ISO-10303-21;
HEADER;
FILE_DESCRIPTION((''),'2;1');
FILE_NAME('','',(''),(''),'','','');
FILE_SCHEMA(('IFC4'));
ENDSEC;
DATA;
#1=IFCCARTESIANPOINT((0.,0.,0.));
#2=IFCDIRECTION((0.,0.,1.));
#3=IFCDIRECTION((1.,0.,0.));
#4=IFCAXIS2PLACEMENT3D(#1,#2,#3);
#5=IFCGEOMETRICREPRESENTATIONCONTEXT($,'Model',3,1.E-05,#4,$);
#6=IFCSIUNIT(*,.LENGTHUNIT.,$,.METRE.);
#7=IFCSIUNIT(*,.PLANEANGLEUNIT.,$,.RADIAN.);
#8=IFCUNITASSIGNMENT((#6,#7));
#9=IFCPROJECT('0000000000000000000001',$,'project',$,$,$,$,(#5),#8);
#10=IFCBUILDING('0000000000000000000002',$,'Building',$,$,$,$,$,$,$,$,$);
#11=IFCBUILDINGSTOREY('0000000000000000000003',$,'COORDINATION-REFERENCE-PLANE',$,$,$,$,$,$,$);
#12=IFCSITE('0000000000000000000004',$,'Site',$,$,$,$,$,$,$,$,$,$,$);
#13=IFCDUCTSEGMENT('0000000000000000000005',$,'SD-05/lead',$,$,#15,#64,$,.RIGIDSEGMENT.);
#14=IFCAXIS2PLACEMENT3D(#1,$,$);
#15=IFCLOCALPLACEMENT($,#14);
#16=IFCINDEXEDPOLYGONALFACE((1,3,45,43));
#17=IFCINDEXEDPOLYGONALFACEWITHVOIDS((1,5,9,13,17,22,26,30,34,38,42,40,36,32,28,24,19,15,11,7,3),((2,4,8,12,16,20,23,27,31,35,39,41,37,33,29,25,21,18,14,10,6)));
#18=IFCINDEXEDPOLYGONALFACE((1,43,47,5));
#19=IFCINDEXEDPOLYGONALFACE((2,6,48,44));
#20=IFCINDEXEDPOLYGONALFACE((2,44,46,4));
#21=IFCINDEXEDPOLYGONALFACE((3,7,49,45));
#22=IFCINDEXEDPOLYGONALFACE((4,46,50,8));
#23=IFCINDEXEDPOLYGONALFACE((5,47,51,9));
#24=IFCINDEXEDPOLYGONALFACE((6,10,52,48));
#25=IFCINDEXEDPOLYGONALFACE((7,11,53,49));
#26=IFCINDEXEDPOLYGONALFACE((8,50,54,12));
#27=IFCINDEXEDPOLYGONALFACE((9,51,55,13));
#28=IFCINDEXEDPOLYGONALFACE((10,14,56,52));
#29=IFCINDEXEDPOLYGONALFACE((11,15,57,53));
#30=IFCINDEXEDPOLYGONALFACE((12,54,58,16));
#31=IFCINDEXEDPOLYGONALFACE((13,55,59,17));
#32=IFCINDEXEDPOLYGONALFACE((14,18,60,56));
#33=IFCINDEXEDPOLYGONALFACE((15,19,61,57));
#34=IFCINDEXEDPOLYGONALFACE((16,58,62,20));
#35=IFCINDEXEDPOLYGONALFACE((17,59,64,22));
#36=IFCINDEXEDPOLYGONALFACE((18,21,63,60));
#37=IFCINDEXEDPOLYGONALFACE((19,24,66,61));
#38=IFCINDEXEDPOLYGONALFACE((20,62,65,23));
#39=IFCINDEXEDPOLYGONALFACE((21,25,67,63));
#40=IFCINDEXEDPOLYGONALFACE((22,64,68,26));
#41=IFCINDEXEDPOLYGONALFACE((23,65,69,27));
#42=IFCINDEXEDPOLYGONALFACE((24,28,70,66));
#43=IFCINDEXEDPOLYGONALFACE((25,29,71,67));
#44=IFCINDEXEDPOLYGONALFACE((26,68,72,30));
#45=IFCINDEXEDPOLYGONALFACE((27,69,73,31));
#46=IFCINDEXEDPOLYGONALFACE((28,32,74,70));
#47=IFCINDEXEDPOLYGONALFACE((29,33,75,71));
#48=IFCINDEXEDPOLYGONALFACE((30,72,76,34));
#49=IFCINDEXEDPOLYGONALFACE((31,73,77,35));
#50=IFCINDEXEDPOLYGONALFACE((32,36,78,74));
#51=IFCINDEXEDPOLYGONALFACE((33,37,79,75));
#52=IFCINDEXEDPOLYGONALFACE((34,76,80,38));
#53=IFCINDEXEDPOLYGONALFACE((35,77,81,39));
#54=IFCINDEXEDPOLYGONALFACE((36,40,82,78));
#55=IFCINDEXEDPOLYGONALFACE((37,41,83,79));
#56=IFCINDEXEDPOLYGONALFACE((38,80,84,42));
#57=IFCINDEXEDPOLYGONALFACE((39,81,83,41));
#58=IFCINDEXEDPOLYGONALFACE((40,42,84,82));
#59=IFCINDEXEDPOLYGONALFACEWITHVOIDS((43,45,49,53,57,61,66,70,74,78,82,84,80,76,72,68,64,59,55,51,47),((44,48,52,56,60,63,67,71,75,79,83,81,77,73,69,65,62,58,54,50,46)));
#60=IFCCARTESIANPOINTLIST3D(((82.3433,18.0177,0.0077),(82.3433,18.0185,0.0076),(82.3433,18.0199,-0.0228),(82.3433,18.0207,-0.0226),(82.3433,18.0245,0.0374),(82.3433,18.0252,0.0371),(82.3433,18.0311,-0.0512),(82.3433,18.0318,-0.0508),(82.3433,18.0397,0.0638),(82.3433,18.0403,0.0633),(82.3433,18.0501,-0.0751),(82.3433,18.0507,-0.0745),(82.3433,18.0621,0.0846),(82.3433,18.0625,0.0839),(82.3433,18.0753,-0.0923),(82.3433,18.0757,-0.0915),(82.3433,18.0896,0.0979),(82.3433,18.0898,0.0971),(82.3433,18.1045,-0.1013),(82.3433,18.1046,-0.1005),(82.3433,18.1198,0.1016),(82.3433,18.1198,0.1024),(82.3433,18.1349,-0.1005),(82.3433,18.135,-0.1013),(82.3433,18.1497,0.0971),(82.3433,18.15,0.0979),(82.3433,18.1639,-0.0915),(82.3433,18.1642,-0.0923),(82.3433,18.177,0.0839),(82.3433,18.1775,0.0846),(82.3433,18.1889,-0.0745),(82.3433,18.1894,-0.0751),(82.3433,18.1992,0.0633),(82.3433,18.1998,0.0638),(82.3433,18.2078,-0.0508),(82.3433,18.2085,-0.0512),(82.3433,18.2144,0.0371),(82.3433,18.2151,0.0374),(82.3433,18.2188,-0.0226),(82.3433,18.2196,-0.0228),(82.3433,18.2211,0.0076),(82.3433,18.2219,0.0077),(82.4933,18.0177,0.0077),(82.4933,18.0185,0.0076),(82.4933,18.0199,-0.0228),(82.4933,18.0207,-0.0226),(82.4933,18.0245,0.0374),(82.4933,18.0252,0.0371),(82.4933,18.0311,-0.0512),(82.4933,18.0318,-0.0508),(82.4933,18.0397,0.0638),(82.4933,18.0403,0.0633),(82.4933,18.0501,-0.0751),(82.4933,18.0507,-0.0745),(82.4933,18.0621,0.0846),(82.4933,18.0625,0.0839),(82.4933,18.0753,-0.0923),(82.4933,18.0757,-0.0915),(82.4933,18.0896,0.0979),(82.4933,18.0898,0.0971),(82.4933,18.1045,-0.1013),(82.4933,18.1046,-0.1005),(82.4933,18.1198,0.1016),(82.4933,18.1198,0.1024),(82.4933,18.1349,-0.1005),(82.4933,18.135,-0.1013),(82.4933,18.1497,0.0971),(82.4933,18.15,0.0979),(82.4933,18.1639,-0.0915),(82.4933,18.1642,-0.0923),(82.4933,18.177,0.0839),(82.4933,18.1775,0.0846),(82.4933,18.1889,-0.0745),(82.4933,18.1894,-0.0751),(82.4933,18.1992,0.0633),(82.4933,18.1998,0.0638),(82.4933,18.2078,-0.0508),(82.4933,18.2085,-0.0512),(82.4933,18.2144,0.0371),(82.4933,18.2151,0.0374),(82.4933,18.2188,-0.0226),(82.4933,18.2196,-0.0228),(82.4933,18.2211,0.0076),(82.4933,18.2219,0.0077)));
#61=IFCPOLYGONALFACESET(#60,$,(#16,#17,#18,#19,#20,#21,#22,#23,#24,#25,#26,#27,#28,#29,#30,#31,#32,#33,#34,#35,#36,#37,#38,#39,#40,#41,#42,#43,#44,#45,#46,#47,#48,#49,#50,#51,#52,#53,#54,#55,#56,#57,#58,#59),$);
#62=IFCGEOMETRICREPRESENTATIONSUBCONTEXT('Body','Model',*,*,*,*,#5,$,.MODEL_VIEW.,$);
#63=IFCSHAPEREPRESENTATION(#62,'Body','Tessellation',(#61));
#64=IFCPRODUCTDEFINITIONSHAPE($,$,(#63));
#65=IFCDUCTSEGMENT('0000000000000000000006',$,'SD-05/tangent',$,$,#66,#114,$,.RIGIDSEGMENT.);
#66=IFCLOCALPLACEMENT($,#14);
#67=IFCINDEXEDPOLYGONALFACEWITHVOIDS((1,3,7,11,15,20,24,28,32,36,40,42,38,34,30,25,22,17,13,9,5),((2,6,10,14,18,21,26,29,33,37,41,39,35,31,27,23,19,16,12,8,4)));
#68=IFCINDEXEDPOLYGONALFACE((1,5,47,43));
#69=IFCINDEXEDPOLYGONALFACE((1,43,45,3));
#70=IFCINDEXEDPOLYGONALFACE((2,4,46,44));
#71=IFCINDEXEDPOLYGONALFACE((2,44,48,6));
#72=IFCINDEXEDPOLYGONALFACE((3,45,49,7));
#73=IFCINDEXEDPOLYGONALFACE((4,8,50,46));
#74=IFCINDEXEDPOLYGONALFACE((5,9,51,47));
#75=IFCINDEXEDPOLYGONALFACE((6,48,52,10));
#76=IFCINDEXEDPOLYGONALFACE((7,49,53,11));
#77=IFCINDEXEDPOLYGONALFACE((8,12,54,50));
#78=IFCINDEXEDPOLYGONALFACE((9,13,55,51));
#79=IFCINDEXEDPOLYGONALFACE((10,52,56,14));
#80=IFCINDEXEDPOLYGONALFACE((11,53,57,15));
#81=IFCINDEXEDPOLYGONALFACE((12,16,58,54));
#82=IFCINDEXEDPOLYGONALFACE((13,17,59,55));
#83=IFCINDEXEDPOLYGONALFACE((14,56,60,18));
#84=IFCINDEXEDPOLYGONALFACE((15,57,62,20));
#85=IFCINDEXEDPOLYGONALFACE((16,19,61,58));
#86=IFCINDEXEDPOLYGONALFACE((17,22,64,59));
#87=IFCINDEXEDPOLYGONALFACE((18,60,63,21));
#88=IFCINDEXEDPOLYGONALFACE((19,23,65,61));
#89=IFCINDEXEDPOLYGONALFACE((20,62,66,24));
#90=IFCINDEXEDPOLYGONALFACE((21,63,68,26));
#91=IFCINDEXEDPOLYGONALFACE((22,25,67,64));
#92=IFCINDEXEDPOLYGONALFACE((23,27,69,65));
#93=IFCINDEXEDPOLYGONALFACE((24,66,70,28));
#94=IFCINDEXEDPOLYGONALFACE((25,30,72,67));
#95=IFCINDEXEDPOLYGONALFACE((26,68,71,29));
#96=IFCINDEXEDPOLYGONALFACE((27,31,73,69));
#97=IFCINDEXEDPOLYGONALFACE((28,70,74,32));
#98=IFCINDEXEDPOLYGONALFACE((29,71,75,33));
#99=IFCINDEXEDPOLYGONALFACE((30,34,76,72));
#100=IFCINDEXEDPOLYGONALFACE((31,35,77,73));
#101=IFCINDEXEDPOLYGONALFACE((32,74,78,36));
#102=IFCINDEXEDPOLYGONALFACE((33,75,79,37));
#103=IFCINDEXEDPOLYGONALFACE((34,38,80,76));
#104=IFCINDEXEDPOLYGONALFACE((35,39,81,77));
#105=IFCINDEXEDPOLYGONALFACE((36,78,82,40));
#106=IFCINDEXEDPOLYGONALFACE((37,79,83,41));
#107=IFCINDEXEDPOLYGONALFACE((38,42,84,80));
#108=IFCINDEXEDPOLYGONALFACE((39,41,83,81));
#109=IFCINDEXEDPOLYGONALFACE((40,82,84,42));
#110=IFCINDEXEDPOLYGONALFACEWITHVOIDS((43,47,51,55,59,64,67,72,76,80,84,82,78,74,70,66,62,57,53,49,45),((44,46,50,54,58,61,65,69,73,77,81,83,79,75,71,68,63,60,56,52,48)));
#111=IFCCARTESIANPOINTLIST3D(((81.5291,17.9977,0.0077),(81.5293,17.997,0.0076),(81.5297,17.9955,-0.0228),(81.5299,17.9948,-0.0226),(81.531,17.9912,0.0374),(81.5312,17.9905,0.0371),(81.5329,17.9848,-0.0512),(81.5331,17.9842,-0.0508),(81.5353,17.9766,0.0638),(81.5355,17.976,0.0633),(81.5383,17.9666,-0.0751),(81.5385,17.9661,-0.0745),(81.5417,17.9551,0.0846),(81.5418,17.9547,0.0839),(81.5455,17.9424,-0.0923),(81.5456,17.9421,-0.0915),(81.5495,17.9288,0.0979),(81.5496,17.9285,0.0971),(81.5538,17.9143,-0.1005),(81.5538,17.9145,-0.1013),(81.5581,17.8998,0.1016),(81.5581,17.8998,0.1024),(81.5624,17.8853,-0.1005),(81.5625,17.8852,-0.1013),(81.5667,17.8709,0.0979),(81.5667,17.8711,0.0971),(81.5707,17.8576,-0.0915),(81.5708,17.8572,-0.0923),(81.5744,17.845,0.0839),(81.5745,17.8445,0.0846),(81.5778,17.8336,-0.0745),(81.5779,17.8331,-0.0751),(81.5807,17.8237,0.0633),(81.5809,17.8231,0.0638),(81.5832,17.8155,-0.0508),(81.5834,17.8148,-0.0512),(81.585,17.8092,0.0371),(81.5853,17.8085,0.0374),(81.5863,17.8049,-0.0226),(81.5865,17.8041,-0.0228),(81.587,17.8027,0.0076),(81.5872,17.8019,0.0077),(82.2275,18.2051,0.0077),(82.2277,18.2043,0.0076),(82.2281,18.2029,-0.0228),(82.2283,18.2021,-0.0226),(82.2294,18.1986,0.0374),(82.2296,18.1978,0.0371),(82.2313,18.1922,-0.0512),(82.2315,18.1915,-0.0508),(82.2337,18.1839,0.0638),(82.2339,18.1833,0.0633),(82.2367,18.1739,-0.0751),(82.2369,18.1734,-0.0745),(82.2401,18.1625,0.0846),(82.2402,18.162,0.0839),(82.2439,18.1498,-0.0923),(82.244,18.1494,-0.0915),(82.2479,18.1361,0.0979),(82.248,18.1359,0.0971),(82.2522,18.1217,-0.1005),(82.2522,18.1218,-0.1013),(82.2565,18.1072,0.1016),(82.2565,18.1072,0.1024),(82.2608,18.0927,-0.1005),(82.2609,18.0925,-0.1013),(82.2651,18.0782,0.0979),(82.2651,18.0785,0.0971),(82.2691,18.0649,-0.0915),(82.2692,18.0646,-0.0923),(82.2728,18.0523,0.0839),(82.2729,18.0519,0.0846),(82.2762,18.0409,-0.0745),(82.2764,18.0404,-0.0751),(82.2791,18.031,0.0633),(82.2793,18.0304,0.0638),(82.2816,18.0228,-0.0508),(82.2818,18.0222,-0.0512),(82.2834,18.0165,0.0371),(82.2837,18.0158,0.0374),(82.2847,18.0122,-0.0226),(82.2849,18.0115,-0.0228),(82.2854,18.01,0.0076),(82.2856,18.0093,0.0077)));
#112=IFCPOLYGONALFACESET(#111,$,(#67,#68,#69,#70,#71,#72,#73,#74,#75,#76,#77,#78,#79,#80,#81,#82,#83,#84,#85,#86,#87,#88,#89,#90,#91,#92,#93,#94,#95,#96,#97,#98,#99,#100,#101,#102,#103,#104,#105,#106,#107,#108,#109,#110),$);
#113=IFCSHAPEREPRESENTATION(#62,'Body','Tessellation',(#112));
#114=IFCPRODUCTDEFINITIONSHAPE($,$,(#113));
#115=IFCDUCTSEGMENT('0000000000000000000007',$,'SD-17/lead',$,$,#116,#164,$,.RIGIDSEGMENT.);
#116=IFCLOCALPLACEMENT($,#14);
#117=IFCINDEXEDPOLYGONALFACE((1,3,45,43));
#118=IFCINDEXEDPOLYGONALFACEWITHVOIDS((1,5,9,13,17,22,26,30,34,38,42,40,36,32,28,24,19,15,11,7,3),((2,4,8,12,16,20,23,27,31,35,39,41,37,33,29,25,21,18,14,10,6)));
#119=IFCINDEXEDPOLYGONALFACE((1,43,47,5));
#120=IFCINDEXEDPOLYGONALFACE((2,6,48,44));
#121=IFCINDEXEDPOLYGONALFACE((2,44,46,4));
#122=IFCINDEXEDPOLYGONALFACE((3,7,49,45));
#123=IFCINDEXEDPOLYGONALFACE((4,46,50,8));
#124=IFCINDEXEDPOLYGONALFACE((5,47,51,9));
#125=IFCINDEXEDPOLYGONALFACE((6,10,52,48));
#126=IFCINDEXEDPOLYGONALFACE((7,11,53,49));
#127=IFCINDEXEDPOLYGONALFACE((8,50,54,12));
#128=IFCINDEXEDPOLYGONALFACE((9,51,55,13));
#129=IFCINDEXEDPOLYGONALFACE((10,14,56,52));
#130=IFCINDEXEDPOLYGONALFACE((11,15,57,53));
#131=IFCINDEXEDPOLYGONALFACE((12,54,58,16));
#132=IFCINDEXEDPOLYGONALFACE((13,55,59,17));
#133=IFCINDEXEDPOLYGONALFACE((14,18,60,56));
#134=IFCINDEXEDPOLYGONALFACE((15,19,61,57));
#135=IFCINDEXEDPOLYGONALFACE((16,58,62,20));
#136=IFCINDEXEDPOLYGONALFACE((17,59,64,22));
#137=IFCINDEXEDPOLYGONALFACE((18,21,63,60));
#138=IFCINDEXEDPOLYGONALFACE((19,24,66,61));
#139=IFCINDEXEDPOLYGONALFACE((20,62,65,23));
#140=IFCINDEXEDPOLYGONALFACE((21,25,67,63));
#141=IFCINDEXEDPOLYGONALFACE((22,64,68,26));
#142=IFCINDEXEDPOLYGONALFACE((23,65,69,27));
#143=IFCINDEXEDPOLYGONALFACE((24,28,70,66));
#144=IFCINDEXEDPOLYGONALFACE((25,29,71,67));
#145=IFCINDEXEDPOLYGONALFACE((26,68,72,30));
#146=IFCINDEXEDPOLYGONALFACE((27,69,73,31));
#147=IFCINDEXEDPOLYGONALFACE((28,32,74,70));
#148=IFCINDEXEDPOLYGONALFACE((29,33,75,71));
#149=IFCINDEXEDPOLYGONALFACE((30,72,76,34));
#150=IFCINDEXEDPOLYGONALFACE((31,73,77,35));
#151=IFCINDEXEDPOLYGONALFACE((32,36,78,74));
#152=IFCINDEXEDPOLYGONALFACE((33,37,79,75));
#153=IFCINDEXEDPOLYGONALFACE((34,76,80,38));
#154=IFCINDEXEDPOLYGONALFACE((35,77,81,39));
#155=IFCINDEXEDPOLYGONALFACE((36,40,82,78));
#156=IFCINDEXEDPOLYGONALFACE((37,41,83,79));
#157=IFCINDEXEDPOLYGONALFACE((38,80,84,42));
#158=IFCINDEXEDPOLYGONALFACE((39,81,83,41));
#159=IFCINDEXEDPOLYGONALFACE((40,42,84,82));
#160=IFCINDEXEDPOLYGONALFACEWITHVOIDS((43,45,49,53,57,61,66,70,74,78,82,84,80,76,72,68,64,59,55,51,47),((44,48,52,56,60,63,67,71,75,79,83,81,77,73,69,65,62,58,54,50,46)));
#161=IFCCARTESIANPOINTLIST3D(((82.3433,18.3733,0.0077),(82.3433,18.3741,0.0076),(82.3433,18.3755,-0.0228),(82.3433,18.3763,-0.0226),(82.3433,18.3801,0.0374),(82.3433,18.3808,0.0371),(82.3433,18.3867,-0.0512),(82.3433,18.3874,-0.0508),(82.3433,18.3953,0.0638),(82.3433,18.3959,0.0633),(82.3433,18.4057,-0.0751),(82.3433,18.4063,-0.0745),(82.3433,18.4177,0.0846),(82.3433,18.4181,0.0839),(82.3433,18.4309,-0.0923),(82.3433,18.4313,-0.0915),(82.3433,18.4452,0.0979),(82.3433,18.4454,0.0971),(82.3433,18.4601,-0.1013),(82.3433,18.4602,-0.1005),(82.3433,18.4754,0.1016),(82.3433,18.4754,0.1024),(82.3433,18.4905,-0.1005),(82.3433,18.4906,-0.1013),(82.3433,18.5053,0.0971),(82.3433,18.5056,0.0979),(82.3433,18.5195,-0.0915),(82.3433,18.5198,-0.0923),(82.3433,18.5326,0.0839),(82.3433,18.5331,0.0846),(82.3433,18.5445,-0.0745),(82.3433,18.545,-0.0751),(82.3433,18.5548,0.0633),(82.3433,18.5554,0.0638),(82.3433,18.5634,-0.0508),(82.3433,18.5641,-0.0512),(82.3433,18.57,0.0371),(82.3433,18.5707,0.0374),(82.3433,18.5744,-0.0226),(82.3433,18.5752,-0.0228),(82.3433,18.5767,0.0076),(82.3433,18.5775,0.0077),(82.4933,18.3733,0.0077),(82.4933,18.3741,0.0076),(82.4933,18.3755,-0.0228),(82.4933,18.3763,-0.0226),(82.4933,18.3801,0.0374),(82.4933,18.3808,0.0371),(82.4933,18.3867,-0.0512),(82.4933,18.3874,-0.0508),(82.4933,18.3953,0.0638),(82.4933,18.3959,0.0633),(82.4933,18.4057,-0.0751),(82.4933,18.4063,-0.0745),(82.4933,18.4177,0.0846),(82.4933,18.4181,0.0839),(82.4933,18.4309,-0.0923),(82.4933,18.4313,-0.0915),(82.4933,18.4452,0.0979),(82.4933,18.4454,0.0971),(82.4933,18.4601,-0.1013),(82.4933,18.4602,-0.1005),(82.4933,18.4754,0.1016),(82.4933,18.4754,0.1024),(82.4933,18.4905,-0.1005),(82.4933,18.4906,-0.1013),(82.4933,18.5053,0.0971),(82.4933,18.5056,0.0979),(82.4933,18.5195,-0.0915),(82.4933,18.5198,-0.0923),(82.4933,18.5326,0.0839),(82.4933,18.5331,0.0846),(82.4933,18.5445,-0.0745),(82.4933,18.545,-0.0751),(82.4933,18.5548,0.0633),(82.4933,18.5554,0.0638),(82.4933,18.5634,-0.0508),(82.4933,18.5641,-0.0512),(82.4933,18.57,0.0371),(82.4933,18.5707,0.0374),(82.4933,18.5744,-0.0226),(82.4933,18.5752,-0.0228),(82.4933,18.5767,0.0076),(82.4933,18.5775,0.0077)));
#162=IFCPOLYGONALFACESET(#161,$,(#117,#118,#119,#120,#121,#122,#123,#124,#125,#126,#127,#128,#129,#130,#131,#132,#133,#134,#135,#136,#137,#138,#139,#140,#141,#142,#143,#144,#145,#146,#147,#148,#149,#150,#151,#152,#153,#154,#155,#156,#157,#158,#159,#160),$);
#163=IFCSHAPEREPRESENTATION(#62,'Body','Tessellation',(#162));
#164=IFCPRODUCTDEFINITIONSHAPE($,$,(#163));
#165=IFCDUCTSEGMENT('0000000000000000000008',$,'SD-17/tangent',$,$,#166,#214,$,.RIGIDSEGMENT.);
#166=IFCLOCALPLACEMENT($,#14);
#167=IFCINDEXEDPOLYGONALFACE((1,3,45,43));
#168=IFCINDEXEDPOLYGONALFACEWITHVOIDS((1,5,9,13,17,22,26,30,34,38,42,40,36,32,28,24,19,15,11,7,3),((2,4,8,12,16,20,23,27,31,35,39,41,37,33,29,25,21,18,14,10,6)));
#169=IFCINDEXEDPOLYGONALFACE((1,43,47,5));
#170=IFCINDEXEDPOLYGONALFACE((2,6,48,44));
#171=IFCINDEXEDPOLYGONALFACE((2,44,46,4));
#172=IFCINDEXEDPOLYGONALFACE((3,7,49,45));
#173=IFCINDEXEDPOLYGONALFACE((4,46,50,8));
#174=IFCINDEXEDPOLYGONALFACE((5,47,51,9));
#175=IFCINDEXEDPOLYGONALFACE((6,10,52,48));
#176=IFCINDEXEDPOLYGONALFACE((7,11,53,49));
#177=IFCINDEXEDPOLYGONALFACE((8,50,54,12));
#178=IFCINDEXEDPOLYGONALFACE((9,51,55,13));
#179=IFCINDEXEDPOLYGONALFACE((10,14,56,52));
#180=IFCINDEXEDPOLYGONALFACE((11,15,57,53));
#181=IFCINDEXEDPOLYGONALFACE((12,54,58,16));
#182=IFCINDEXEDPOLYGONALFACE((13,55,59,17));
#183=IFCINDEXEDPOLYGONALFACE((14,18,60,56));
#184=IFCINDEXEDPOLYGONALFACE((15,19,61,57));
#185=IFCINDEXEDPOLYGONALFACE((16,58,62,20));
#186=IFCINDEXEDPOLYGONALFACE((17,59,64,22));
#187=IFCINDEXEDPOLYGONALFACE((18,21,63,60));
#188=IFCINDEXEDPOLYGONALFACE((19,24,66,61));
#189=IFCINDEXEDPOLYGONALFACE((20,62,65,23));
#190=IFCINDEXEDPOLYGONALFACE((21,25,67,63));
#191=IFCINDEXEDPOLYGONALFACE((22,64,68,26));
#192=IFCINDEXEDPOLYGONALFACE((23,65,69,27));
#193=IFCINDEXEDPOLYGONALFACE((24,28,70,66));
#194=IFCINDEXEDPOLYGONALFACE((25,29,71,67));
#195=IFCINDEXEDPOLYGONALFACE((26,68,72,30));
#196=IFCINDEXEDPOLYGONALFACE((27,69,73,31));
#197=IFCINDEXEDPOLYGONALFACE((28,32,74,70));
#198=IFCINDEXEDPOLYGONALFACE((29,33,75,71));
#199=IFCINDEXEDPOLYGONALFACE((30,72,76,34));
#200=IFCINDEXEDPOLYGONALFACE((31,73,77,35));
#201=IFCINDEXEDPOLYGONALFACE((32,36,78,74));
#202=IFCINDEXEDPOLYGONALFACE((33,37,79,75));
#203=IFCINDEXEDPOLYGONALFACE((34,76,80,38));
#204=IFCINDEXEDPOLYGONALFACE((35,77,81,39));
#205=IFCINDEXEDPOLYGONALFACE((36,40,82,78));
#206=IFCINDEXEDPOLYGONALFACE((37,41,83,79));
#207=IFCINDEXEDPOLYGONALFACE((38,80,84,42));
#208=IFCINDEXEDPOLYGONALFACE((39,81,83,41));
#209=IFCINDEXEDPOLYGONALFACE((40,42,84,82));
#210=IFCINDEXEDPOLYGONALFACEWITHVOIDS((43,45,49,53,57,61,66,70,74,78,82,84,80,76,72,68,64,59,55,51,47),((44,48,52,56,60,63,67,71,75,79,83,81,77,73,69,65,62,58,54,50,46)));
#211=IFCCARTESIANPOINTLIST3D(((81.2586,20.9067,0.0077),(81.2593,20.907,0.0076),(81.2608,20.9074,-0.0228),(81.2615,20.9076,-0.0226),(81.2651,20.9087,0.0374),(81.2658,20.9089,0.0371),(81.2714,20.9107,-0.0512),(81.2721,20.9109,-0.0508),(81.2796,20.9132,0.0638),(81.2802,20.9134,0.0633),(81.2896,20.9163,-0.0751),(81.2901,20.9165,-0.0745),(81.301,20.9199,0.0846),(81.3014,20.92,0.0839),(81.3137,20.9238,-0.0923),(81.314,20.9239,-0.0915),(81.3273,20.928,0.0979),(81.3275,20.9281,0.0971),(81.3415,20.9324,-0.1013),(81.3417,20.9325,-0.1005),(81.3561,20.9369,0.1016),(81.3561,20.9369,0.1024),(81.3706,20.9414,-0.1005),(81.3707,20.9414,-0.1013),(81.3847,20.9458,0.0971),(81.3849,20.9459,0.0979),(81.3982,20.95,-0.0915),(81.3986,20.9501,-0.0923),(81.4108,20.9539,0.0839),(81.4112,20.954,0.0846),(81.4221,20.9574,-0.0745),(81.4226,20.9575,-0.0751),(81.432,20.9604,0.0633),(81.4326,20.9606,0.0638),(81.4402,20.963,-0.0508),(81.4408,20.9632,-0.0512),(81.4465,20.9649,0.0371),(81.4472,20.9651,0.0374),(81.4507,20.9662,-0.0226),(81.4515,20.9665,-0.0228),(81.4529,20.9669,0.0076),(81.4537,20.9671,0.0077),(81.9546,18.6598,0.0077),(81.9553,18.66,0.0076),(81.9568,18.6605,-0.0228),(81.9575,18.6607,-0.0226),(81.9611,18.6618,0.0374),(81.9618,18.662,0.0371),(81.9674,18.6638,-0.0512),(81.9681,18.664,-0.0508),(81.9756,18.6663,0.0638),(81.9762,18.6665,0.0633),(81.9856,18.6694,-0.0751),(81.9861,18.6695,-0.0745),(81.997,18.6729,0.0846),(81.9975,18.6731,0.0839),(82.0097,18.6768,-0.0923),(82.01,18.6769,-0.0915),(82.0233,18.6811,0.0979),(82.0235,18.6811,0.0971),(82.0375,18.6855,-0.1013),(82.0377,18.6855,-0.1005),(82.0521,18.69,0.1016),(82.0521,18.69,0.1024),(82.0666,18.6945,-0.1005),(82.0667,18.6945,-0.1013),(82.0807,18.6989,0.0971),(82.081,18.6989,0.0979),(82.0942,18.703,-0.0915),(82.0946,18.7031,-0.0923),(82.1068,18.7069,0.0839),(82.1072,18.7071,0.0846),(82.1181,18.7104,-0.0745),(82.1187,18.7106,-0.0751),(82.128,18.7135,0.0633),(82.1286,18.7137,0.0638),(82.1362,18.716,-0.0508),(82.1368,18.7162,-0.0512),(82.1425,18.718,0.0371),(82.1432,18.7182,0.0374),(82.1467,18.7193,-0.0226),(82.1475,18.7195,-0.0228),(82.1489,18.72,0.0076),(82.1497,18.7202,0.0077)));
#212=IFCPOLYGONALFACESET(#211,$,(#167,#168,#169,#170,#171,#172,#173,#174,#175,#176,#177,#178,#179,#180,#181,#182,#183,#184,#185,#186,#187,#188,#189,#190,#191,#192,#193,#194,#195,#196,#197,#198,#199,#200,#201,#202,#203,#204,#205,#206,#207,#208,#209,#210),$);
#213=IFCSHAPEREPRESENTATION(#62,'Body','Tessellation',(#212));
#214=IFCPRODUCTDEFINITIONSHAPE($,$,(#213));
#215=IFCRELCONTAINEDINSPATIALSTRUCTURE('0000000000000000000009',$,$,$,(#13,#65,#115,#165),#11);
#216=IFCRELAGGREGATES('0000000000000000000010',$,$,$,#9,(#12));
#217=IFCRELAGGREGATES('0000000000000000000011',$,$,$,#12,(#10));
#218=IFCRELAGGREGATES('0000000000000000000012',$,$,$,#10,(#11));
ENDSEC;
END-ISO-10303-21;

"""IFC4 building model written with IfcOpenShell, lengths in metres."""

from ifc_helpers import new_model, si_unit, frame, origin_with_axes, place, context, subcontext, project, spatial, hollow_circle, extrude, element, save


model = new_model("IFC4")

# Units and contexts
model_context_1 = context("Model", 3, precision=1e-05, world=origin_with_axes())
body_context_1 = subcontext(model_context_1, "Body", "Model", "MODEL_VIEW")
ifc_project = project(units=[si_unit("LENGTHUNIT", "METRE"), si_unit("PLANEANGLEUNIT", "RADIAN")], contexts=[model_context_1])

# Site, building, storey
site = spatial("IfcSite", under=ifc_project, Name="Site")
building = spatial("IfcBuilding", under=site, Name="Building")
storey = spatial("IfcBuildingStorey", under=building, Name="COORDINATION-REFERENCE-PLANE")

# Duct segment
duct_segment_1_placement = place(None, frame((82.4933, 18.1198, 0.0), z_axis=(-1.0, 0.0, 0.0), x_axis=(0.0, 0.0, 1.0)))
element("IfcDuctSegment", 1, at=duct_segment_1_placement, inside=storey, Name="SD-05/lead", PredefinedType="RIGIDSEGMENT", context=body_context_1, shape_type="SweptSolid", body=[
    extrude(hollow_circle(Radius=0.1024, WallThickness=0.0008), origin_with_axes(), (0.0, 0.0, 1.0), 0.15),
])

# Duct segment
duct_segment_2_placement = place(None, frame((82.2565, 18.1072, 0.0), z_axis=(-0.958645, -0.284603, 0.0), x_axis=(0.0, 0.0, 1.0)))
element("IfcDuctSegment", 2, at=duct_segment_2_placement, inside=storey, Name="SD-05/tangent", PredefinedType="RIGIDSEGMENT", context=body_context_1, shape_type="SweptSolid", body=[
    extrude(hollow_circle(Radius=0.1024, WallThickness=0.0008), origin_with_axes(), (0.0, 0.0, 1.0), 0.7285),
])

# Duct segment
duct_segment_3_placement = place(None, frame((82.4933, 18.4754, 0.0), z_axis=(-1.0, 0.0, 0.0), x_axis=(0.0, 0.0, 1.0)))
element("IfcDuctSegment", 3, at=duct_segment_3_placement, inside=storey, Name="SD-17/lead", PredefinedType="RIGIDSEGMENT", context=body_context_1, shape_type="SweptSolid", body=[
    extrude(hollow_circle(Radius=0.1024, WallThickness=0.0008), origin_with_axes(), (0.0, 0.0, 1.0), 0.15),
])

# Duct segment
duct_segment_4_placement = place(None, frame((82.0521, 18.69, 0.0), z_axis=(-0.295887, 0.955223, 0.0), x_axis=(0.0, 0.0, 1.0)))
element("IfcDuctSegment", 4, at=duct_segment_4_placement, inside=storey, Name="SD-17/tangent", PredefinedType="RIGIDSEGMENT", context=body_context_1, shape_type="SweptSolid", body=[
    extrude(hollow_circle(Radius=0.1024, WallThickness=0.0008), origin_with_axes(), (0.0, 0.0, 1.0), 2.3523),
])

save(model, "model.ifc")
